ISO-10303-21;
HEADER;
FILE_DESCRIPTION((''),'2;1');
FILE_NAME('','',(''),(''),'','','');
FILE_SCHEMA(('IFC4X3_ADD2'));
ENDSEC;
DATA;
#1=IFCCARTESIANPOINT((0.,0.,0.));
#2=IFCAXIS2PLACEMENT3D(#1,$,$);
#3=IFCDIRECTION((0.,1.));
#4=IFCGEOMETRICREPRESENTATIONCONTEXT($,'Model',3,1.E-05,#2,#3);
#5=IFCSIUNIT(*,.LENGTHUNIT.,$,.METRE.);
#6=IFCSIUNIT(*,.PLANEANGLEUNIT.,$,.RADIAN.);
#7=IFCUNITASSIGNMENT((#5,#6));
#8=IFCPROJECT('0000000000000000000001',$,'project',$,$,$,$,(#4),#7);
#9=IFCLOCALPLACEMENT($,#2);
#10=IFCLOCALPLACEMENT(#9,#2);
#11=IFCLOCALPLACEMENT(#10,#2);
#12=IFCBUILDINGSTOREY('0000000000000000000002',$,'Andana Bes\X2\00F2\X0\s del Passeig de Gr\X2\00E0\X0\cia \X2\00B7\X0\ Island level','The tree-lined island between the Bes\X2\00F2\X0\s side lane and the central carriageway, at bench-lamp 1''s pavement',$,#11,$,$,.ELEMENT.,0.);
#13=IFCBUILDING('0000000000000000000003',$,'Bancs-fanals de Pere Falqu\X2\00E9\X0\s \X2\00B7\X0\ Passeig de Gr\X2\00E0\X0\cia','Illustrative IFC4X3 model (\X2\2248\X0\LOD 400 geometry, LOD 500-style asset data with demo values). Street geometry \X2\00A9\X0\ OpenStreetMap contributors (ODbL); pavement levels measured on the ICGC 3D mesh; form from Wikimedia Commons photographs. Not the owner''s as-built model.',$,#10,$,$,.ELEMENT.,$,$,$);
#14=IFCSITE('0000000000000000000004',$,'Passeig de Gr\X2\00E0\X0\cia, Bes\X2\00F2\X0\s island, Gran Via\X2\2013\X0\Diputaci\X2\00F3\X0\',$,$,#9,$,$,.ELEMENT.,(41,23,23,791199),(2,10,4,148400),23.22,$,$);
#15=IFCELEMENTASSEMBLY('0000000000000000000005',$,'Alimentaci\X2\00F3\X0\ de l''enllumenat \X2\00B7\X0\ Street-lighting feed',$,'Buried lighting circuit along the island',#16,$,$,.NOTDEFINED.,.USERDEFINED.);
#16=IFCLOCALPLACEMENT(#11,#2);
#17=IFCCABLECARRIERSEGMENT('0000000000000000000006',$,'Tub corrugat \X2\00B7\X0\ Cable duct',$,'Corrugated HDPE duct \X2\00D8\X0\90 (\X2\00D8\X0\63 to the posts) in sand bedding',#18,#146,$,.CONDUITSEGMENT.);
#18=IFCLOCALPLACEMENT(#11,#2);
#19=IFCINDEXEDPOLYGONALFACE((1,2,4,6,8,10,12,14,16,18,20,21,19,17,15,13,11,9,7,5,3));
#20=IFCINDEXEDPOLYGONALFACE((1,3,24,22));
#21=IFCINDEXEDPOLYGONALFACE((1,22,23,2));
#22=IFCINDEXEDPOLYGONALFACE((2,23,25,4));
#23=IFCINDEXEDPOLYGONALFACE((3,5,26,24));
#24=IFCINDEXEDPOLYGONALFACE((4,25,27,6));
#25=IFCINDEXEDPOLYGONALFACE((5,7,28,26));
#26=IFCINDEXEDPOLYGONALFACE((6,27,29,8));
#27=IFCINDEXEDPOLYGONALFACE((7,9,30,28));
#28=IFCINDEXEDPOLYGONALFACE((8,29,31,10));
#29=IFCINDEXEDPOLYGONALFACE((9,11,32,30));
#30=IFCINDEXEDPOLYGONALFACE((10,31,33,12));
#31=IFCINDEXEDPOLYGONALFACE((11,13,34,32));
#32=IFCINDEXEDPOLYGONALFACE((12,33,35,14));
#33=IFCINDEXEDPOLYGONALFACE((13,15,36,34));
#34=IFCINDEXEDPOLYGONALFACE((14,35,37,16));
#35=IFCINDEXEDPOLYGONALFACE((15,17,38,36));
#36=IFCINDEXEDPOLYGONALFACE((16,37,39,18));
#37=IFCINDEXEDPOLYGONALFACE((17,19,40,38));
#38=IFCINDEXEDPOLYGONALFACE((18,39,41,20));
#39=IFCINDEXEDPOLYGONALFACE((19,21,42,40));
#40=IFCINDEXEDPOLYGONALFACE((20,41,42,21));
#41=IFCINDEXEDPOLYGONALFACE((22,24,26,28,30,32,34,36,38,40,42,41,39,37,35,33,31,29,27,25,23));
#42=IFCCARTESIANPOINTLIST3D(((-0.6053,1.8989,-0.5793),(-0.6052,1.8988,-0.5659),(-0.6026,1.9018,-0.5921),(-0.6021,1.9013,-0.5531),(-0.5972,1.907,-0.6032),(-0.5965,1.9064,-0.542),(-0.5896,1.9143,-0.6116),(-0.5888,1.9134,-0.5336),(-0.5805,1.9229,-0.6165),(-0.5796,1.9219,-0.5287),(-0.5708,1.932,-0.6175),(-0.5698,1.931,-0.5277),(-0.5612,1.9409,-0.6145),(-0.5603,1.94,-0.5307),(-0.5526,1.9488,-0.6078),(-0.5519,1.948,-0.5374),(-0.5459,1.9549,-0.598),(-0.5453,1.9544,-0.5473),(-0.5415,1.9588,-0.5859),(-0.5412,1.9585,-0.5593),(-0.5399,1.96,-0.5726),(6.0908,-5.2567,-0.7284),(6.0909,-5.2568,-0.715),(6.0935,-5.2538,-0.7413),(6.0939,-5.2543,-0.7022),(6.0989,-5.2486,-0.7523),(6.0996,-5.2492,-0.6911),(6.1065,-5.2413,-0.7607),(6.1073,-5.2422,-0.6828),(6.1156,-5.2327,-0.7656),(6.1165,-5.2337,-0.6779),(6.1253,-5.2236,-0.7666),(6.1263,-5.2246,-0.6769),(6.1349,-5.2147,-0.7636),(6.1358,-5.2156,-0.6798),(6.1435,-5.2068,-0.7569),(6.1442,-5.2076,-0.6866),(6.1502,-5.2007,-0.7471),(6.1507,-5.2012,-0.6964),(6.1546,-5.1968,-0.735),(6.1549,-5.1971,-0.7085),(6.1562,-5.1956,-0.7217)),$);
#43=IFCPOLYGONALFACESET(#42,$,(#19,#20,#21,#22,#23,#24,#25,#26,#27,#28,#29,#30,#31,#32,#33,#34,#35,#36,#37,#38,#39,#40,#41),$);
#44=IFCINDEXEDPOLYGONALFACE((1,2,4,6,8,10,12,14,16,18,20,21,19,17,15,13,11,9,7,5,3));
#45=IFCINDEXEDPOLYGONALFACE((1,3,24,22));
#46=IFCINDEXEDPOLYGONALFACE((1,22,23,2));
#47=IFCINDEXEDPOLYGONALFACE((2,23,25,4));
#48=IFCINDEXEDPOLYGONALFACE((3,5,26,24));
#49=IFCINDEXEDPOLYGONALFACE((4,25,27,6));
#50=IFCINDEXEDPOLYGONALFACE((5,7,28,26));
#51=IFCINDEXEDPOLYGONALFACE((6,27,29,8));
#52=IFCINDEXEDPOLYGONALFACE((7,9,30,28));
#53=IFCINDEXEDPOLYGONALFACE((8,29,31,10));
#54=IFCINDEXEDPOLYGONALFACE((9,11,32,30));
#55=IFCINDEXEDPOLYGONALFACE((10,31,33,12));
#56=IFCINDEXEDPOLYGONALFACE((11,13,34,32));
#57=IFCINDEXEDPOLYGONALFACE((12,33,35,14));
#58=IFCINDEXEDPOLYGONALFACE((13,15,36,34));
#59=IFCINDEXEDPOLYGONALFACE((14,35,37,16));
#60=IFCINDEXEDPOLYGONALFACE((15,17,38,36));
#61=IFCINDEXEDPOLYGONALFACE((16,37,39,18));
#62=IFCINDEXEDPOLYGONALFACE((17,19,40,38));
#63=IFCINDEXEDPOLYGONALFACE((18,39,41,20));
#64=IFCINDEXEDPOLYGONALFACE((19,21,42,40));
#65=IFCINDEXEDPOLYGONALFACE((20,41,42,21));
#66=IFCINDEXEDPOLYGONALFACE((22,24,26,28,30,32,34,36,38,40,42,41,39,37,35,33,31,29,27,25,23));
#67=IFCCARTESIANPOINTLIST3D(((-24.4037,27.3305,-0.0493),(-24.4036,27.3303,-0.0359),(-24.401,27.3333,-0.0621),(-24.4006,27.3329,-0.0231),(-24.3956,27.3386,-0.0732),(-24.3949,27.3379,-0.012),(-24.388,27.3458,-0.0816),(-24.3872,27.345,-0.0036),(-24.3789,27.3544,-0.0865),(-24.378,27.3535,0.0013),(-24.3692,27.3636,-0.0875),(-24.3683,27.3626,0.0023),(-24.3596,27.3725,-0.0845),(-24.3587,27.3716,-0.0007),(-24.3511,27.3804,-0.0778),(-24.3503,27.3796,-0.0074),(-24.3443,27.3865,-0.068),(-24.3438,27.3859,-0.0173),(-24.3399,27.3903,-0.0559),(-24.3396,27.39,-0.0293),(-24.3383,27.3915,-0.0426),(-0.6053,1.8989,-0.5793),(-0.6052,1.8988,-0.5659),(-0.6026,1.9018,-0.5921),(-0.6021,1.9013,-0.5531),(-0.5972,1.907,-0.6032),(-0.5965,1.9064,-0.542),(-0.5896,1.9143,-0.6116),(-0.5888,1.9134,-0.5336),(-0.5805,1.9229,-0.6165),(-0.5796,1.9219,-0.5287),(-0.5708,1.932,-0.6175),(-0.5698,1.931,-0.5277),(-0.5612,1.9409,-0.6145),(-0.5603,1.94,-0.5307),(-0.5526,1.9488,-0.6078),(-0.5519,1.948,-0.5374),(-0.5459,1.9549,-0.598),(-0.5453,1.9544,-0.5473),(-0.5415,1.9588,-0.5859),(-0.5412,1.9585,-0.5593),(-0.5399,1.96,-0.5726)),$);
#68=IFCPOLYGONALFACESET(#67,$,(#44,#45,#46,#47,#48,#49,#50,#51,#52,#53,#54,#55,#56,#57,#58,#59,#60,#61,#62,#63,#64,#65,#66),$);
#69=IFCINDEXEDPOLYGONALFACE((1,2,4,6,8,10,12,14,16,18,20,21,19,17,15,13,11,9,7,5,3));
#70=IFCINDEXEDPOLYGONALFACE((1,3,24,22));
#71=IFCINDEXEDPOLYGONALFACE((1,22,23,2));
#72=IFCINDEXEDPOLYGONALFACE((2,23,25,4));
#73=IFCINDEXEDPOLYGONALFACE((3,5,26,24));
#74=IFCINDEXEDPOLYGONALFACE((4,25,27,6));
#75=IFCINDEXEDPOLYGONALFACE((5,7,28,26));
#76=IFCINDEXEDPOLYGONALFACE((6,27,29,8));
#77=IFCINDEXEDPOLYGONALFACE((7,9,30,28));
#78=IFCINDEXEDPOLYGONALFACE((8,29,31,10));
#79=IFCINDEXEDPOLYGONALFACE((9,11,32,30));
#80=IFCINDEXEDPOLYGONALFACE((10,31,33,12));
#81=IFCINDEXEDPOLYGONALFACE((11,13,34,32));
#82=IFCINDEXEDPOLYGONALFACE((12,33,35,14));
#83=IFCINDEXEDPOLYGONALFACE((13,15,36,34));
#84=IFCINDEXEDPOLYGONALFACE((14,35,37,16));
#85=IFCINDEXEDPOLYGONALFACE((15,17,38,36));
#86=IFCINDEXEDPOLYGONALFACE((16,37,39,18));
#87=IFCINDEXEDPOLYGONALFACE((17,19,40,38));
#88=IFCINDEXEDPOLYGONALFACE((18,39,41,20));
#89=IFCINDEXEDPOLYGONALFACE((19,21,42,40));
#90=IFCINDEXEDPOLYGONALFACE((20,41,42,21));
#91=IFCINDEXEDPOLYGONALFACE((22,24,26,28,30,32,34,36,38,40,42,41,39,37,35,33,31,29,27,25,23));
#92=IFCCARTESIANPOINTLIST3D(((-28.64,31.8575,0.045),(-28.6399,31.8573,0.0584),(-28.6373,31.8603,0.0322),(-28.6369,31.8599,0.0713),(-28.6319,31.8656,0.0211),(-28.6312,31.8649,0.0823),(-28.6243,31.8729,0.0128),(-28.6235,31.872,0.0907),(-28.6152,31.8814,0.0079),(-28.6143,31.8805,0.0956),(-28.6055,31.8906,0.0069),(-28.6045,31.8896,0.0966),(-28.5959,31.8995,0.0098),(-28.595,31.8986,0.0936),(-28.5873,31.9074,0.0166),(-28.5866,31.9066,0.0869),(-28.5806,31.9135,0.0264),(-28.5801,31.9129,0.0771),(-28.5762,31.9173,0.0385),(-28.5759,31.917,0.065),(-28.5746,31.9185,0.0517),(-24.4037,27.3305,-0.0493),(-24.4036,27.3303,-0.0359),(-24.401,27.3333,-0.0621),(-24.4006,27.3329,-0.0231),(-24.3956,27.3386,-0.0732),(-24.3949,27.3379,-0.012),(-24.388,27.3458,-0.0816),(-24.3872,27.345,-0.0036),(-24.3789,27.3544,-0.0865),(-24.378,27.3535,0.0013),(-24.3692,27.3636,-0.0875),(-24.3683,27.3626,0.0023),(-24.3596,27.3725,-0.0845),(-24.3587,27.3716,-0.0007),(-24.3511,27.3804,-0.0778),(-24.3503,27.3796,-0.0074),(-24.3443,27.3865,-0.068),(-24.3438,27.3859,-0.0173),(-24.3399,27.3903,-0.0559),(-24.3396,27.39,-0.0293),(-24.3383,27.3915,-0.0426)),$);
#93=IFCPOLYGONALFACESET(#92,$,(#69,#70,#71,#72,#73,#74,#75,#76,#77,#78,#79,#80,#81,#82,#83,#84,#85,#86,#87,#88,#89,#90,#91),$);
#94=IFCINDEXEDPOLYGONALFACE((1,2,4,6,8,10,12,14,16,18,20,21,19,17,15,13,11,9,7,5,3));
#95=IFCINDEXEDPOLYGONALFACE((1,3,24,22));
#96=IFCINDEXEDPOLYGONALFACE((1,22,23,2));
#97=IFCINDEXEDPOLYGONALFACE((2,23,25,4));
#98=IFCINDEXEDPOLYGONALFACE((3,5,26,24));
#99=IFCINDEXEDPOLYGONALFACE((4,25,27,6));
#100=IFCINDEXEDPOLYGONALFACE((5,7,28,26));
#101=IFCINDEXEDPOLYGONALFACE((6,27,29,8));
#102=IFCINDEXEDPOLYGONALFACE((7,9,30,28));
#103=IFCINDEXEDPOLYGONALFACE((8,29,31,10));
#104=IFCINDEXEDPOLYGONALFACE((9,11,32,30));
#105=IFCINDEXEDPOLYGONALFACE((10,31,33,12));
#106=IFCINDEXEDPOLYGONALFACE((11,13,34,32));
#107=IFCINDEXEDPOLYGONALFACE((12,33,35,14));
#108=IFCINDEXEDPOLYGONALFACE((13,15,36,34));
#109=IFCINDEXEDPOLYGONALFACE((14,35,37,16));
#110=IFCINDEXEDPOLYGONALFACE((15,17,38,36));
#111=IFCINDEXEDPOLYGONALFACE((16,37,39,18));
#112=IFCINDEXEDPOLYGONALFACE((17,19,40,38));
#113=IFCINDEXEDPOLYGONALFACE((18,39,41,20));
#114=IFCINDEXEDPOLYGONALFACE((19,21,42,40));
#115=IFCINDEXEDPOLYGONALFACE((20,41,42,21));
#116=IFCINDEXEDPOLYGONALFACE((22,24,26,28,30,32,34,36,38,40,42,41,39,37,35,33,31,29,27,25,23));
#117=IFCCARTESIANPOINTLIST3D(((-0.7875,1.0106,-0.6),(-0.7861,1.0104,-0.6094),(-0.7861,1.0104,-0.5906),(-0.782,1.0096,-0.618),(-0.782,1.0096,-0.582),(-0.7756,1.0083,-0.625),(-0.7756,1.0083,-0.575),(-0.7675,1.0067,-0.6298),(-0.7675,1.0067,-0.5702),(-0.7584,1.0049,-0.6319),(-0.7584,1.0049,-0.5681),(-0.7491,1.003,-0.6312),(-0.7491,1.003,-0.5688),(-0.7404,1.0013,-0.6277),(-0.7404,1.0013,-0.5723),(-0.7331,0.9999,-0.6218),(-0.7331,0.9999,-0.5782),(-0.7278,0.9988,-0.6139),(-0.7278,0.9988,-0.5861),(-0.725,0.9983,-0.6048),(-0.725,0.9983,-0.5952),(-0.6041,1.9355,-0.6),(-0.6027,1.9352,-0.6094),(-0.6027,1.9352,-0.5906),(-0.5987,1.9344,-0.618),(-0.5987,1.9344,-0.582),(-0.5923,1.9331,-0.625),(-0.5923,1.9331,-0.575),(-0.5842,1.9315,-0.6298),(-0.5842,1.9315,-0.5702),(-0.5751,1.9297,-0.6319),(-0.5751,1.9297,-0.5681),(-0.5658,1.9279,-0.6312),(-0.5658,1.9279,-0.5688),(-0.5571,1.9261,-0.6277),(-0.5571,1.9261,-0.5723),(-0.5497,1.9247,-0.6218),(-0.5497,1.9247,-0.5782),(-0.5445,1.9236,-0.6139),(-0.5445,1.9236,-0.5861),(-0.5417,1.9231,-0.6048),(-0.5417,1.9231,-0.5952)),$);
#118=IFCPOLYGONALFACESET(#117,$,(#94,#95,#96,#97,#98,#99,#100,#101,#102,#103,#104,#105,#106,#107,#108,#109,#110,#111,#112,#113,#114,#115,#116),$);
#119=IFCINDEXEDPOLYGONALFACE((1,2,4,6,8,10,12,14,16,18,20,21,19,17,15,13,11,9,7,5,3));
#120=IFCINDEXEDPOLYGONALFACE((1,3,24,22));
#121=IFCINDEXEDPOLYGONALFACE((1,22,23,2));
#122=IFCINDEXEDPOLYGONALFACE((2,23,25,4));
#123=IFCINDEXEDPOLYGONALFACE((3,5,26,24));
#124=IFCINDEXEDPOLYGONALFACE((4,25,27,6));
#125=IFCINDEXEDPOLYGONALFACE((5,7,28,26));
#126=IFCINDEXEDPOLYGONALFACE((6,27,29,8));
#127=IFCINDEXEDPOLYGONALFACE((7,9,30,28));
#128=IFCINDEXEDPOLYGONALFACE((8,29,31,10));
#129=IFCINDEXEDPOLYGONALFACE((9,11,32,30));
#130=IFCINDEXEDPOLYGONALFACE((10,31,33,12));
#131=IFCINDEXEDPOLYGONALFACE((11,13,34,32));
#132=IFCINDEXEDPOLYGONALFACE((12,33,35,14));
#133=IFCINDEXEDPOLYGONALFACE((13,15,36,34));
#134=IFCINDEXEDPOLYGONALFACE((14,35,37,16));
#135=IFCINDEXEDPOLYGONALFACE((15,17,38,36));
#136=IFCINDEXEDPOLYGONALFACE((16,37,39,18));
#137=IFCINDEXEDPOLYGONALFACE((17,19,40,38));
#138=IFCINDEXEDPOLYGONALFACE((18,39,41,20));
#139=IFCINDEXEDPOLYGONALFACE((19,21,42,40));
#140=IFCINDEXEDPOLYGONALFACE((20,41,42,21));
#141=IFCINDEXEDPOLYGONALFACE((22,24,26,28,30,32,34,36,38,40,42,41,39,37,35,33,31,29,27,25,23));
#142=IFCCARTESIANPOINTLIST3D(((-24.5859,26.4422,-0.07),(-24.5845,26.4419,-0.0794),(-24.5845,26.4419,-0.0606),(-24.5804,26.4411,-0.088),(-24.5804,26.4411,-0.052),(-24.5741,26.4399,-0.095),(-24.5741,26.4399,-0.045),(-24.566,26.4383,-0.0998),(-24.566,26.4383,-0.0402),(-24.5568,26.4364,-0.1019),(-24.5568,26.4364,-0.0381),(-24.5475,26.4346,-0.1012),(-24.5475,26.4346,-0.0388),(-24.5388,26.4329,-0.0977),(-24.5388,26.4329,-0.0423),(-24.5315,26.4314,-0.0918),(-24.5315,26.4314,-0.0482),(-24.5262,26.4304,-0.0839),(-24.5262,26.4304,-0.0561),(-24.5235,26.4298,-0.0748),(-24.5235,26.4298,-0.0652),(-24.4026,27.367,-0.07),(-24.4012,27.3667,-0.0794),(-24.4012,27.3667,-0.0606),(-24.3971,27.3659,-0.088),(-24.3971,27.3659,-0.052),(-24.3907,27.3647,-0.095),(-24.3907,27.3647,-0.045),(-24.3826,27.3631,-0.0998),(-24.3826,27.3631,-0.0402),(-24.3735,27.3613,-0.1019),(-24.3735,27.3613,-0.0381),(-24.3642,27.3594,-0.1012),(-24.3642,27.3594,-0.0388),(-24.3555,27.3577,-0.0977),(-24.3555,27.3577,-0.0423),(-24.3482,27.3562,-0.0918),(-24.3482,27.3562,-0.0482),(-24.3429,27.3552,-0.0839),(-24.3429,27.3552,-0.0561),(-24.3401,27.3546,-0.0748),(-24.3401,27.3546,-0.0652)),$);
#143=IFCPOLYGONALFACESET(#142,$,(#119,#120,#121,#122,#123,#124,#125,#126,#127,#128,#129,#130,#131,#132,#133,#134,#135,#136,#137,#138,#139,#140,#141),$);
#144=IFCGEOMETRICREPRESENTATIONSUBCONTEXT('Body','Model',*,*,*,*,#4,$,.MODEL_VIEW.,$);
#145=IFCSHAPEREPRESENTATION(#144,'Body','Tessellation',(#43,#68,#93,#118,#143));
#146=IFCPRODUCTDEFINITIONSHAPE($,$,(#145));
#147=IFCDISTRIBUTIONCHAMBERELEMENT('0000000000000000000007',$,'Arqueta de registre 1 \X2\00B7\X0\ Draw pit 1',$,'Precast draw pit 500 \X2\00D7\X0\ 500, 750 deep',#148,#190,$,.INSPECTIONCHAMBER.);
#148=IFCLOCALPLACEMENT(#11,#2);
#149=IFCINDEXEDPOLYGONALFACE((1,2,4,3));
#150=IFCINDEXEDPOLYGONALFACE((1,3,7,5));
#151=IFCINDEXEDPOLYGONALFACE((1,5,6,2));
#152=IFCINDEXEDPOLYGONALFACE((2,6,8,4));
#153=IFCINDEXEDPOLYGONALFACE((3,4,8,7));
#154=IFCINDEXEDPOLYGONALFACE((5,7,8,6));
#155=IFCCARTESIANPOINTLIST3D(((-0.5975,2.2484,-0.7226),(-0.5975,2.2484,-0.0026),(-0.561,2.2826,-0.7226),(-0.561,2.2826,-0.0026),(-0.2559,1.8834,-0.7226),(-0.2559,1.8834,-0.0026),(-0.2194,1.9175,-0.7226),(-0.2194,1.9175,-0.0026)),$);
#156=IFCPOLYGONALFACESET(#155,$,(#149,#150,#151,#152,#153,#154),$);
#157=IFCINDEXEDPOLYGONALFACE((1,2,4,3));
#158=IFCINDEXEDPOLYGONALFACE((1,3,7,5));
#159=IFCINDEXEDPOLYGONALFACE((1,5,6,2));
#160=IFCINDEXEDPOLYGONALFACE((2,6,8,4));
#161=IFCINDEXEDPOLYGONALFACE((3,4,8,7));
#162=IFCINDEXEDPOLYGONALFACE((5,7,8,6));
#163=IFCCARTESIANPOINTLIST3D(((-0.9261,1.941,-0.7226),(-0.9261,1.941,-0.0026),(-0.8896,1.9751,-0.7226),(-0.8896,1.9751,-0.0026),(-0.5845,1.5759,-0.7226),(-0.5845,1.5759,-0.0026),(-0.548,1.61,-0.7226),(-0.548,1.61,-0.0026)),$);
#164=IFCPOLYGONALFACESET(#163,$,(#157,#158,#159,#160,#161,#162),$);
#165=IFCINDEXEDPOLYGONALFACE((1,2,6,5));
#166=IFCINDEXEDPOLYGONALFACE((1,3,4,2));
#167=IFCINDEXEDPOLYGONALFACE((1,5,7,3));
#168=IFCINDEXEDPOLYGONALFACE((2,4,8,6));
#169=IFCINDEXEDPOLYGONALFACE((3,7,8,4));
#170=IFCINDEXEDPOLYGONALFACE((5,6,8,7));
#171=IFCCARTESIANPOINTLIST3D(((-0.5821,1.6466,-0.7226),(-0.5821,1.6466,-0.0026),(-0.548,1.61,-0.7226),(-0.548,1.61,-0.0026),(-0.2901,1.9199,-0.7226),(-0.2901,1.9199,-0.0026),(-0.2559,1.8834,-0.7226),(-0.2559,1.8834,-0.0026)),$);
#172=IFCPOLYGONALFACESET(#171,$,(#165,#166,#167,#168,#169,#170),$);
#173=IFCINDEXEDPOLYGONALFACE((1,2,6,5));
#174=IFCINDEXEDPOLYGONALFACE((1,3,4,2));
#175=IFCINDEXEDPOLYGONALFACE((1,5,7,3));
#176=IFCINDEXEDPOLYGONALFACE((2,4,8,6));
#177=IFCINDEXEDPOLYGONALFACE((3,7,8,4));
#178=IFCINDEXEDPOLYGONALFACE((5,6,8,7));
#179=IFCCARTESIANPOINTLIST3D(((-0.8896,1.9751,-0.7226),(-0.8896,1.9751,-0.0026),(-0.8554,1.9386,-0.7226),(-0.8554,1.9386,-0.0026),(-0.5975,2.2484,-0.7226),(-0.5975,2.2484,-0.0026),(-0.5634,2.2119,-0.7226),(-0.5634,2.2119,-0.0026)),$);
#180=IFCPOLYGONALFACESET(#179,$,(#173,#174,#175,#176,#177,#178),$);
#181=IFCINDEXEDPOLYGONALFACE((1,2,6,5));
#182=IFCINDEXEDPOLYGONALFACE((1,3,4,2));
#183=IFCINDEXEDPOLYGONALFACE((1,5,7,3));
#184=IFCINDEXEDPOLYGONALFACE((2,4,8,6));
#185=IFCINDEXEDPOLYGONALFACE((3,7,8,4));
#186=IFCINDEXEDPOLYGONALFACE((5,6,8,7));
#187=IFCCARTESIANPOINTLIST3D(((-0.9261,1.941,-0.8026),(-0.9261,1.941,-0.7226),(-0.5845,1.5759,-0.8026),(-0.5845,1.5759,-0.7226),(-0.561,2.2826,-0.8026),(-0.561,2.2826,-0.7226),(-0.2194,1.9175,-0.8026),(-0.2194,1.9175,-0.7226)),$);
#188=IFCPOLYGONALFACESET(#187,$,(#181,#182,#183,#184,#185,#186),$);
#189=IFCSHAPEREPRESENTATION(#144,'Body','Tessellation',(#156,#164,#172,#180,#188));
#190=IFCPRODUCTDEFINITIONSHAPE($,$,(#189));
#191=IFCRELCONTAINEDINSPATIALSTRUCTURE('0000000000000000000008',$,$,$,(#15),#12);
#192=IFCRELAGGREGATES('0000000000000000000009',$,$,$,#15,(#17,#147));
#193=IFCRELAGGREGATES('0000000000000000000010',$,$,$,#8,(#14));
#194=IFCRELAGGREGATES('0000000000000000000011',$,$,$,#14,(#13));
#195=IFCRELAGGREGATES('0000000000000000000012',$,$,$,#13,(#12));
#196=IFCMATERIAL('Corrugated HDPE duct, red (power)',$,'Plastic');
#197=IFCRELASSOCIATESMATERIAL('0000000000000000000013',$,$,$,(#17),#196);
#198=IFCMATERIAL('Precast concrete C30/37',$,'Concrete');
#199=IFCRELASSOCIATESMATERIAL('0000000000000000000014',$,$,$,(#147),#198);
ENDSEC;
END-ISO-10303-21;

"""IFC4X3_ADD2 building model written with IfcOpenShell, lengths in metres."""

from ifc_helpers import new_model, si_unit, direction, frame, frame_2d, origin, origin_2d_with_axis, place, context, subcontext, project, spatial, rectangle, circle, extrude, material, element, aggregate, save


model = new_model("IFC4X3_ADD2")

# Units and contexts
model_context = context("Model", 3, precision=1e-05, world=origin(), true_north=direction((0.0, 1.0)))
body_context = subcontext(model_context, "Body", "Model", "MODEL_VIEW")
ifc_project = project(units=[si_unit("LENGTHUNIT", "METRE"), si_unit("PLANEANGLEUNIT", "RADIAN")], contexts=[model_context])

# Site, building, storey
site_placement = place(None, origin())
site = spatial("IfcSite", under=ifc_project, at=site_placement, Name="Passeig de Gràcia, Besòs island, Gran Via–Diputació", CompositionType="ELEMENT", RefLatitude=(41, 23, 23, 791199), RefLongitude=(2, 10, 4, 148400), RefElevation=23.22)
building_placement = place(site_placement, origin())
building = spatial("IfcBuilding", under=site, at=building_placement, Name="Bancs-fanals de Pere Falqués · Passeig de Gràcia", Description="Illustrative IFC4X3 model (≈LOD 400 geometry, LOD 500-style asset data with demo values). Street geometry © OpenStreetMap contributors (ODbL); pavement levels measured on the ICGC 3D mesh; form from Wikimedia Commons photographs. Not the owner's as-built model.", CompositionType="ELEMENT")
storey_placement = place(building_placement, origin())
storey = spatial("IfcBuildingStorey", under=building, at=storey_placement, Name="Andana Besòs del Passeig de Gràcia · Island level", Description="The tree-lined island between the Besòs side lane and the central carriageway, at bench-lamp 1's pavement", CompositionType="ELEMENT", Elevation=0.0)

# Element assembly
assembly_1_placement = place(building_placement, origin())
assembly_1 = element("IfcElementAssembly", 1, at=assembly_1_placement, inside=storey, Name="Alimentació de l'enllumenat · Street-lighting feed", ObjectType="Buried lighting circuit along the island", AssemblyPlace="NOTDEFINED", PredefinedType="USERDEFINED")

# Cable carrier segment
ifc_material_1 = material(Name="Corrugated HDPE duct, red (power)", Category="Plastic")
cable_carrier_segment_placement = place(building_placement, origin())
cable_carrier_segment = element("IfcCableCarrierSegment", 2, at=cable_carrier_segment_placement, material=ifc_material_1, Name="Tub corrugat · Cable duct", ObjectType="Corrugated HDPE duct Ø90 (Ø63 to the posts) in sand bedding", PredefinedType="CONDUITSEGMENT", context=body_context, shape_type="SweptSolid", body=[
    extrude(circle(Radius=0.045, at=origin_2d_with_axis()), frame((6.1233, -5.2264, -0.7217), z_axis=(-0.683195, 0.730078, 0.015215), x_axis=(0.730162, 0.683274, 0.0)), (0.0, 0.0, 1.0), 9.8011),
    extrude(circle(Radius=0.045, at=origin_2d_with_axis()), frame((-0.5727, 1.9292, -0.5726), z_axis=(-0.683195, 0.730078, 0.015215), x_axis=(0.730162, 0.683274, 0.0)), (0.0, 0.0, 1.0), 34.834),
    extrude(circle(Radius=0.045, at=origin_2d_with_axis()), frame((-24.3712, 27.3608, -0.0426), z_axis=(-0.683195, 0.730078, 0.015215), x_axis=(0.730162, 0.683274, 0.0)), (0.0, 0.0, 1.0), 6.2007),
    extrude(circle(Radius=0.032, at=origin_2d_with_axis()), frame((-0.5727, 1.9292, -0.6), z_axis=(-0.194449, -0.980913, 0.0), x_axis=(-0.980913, 0.194449, 0.0)), (0.0, 0.0, 1.0), 0.9428),
    extrude(circle(Radius=0.032, at=origin_2d_with_axis()), frame((-24.3712, 27.3608, -0.07), z_axis=(-0.194449, -0.980913, 0.0), x_axis=(-0.980913, 0.194449, 0.0)), (0.0, 0.0, 1.0), 0.9428),
])

# Distribution chamber element
ifc_material_2 = material(Name="Precast concrete C30/37", Category="Concrete")
distribution_chamber_element_1_placement = place(building_placement, origin())
distribution_chamber_element_1 = element("IfcDistributionChamberElement", 3, at=distribution_chamber_element_1_placement, material=ifc_material_2, Name="Arqueta de registre 1 · Draw pit 1", ObjectType="Precast draw pit 500 × 500, 750 deep", PredefinedType="INSPECTIONCHAMBER", context=body_context, shape_type="SweptSolid", body=[
    extrude(rectangle(XDim=0.5, YDim=0.05, at=frame_2d((0.0, 0.0), x_axis=(-0.683274, 0.730162))), frame((-0.4085, 2.083, -0.7226)), (0.0, 0.0, 1.0), 0.72),
    extrude(rectangle(XDim=0.5, YDim=0.05, at=frame_2d((0.0, 0.0), x_axis=(-0.683274, 0.730162))), frame((-0.737, 1.7755, -0.7226)), (0.0, 0.0, 1.0), 0.72),
    extrude(rectangle(XDim=0.05, YDim=0.4, at=frame_2d((0.0, 0.0), x_axis=(-0.683274, 0.730162))), frame((-0.419, 1.765, -0.7226)), (0.0, 0.0, 1.0), 0.72),
    extrude(rectangle(XDim=0.05, YDim=0.4, at=frame_2d((0.0, 0.0), x_axis=(-0.683274, 0.730162))), frame((-0.7265, 2.0935, -0.7226)), (0.0, 0.0, 1.0), 0.72),
    extrude(rectangle(XDim=0.5, YDim=0.5, at=frame_2d((0.0, 0.0), x_axis=(-0.683274, 0.730162))), frame((-0.5727, 1.9292, -0.8026)), (0.0, 0.0, 1.0), 0.08),
])
aggregate(assembly_1, [cable_carrier_segment, distribution_chamber_element_1])

save(model, "model.ifc")
